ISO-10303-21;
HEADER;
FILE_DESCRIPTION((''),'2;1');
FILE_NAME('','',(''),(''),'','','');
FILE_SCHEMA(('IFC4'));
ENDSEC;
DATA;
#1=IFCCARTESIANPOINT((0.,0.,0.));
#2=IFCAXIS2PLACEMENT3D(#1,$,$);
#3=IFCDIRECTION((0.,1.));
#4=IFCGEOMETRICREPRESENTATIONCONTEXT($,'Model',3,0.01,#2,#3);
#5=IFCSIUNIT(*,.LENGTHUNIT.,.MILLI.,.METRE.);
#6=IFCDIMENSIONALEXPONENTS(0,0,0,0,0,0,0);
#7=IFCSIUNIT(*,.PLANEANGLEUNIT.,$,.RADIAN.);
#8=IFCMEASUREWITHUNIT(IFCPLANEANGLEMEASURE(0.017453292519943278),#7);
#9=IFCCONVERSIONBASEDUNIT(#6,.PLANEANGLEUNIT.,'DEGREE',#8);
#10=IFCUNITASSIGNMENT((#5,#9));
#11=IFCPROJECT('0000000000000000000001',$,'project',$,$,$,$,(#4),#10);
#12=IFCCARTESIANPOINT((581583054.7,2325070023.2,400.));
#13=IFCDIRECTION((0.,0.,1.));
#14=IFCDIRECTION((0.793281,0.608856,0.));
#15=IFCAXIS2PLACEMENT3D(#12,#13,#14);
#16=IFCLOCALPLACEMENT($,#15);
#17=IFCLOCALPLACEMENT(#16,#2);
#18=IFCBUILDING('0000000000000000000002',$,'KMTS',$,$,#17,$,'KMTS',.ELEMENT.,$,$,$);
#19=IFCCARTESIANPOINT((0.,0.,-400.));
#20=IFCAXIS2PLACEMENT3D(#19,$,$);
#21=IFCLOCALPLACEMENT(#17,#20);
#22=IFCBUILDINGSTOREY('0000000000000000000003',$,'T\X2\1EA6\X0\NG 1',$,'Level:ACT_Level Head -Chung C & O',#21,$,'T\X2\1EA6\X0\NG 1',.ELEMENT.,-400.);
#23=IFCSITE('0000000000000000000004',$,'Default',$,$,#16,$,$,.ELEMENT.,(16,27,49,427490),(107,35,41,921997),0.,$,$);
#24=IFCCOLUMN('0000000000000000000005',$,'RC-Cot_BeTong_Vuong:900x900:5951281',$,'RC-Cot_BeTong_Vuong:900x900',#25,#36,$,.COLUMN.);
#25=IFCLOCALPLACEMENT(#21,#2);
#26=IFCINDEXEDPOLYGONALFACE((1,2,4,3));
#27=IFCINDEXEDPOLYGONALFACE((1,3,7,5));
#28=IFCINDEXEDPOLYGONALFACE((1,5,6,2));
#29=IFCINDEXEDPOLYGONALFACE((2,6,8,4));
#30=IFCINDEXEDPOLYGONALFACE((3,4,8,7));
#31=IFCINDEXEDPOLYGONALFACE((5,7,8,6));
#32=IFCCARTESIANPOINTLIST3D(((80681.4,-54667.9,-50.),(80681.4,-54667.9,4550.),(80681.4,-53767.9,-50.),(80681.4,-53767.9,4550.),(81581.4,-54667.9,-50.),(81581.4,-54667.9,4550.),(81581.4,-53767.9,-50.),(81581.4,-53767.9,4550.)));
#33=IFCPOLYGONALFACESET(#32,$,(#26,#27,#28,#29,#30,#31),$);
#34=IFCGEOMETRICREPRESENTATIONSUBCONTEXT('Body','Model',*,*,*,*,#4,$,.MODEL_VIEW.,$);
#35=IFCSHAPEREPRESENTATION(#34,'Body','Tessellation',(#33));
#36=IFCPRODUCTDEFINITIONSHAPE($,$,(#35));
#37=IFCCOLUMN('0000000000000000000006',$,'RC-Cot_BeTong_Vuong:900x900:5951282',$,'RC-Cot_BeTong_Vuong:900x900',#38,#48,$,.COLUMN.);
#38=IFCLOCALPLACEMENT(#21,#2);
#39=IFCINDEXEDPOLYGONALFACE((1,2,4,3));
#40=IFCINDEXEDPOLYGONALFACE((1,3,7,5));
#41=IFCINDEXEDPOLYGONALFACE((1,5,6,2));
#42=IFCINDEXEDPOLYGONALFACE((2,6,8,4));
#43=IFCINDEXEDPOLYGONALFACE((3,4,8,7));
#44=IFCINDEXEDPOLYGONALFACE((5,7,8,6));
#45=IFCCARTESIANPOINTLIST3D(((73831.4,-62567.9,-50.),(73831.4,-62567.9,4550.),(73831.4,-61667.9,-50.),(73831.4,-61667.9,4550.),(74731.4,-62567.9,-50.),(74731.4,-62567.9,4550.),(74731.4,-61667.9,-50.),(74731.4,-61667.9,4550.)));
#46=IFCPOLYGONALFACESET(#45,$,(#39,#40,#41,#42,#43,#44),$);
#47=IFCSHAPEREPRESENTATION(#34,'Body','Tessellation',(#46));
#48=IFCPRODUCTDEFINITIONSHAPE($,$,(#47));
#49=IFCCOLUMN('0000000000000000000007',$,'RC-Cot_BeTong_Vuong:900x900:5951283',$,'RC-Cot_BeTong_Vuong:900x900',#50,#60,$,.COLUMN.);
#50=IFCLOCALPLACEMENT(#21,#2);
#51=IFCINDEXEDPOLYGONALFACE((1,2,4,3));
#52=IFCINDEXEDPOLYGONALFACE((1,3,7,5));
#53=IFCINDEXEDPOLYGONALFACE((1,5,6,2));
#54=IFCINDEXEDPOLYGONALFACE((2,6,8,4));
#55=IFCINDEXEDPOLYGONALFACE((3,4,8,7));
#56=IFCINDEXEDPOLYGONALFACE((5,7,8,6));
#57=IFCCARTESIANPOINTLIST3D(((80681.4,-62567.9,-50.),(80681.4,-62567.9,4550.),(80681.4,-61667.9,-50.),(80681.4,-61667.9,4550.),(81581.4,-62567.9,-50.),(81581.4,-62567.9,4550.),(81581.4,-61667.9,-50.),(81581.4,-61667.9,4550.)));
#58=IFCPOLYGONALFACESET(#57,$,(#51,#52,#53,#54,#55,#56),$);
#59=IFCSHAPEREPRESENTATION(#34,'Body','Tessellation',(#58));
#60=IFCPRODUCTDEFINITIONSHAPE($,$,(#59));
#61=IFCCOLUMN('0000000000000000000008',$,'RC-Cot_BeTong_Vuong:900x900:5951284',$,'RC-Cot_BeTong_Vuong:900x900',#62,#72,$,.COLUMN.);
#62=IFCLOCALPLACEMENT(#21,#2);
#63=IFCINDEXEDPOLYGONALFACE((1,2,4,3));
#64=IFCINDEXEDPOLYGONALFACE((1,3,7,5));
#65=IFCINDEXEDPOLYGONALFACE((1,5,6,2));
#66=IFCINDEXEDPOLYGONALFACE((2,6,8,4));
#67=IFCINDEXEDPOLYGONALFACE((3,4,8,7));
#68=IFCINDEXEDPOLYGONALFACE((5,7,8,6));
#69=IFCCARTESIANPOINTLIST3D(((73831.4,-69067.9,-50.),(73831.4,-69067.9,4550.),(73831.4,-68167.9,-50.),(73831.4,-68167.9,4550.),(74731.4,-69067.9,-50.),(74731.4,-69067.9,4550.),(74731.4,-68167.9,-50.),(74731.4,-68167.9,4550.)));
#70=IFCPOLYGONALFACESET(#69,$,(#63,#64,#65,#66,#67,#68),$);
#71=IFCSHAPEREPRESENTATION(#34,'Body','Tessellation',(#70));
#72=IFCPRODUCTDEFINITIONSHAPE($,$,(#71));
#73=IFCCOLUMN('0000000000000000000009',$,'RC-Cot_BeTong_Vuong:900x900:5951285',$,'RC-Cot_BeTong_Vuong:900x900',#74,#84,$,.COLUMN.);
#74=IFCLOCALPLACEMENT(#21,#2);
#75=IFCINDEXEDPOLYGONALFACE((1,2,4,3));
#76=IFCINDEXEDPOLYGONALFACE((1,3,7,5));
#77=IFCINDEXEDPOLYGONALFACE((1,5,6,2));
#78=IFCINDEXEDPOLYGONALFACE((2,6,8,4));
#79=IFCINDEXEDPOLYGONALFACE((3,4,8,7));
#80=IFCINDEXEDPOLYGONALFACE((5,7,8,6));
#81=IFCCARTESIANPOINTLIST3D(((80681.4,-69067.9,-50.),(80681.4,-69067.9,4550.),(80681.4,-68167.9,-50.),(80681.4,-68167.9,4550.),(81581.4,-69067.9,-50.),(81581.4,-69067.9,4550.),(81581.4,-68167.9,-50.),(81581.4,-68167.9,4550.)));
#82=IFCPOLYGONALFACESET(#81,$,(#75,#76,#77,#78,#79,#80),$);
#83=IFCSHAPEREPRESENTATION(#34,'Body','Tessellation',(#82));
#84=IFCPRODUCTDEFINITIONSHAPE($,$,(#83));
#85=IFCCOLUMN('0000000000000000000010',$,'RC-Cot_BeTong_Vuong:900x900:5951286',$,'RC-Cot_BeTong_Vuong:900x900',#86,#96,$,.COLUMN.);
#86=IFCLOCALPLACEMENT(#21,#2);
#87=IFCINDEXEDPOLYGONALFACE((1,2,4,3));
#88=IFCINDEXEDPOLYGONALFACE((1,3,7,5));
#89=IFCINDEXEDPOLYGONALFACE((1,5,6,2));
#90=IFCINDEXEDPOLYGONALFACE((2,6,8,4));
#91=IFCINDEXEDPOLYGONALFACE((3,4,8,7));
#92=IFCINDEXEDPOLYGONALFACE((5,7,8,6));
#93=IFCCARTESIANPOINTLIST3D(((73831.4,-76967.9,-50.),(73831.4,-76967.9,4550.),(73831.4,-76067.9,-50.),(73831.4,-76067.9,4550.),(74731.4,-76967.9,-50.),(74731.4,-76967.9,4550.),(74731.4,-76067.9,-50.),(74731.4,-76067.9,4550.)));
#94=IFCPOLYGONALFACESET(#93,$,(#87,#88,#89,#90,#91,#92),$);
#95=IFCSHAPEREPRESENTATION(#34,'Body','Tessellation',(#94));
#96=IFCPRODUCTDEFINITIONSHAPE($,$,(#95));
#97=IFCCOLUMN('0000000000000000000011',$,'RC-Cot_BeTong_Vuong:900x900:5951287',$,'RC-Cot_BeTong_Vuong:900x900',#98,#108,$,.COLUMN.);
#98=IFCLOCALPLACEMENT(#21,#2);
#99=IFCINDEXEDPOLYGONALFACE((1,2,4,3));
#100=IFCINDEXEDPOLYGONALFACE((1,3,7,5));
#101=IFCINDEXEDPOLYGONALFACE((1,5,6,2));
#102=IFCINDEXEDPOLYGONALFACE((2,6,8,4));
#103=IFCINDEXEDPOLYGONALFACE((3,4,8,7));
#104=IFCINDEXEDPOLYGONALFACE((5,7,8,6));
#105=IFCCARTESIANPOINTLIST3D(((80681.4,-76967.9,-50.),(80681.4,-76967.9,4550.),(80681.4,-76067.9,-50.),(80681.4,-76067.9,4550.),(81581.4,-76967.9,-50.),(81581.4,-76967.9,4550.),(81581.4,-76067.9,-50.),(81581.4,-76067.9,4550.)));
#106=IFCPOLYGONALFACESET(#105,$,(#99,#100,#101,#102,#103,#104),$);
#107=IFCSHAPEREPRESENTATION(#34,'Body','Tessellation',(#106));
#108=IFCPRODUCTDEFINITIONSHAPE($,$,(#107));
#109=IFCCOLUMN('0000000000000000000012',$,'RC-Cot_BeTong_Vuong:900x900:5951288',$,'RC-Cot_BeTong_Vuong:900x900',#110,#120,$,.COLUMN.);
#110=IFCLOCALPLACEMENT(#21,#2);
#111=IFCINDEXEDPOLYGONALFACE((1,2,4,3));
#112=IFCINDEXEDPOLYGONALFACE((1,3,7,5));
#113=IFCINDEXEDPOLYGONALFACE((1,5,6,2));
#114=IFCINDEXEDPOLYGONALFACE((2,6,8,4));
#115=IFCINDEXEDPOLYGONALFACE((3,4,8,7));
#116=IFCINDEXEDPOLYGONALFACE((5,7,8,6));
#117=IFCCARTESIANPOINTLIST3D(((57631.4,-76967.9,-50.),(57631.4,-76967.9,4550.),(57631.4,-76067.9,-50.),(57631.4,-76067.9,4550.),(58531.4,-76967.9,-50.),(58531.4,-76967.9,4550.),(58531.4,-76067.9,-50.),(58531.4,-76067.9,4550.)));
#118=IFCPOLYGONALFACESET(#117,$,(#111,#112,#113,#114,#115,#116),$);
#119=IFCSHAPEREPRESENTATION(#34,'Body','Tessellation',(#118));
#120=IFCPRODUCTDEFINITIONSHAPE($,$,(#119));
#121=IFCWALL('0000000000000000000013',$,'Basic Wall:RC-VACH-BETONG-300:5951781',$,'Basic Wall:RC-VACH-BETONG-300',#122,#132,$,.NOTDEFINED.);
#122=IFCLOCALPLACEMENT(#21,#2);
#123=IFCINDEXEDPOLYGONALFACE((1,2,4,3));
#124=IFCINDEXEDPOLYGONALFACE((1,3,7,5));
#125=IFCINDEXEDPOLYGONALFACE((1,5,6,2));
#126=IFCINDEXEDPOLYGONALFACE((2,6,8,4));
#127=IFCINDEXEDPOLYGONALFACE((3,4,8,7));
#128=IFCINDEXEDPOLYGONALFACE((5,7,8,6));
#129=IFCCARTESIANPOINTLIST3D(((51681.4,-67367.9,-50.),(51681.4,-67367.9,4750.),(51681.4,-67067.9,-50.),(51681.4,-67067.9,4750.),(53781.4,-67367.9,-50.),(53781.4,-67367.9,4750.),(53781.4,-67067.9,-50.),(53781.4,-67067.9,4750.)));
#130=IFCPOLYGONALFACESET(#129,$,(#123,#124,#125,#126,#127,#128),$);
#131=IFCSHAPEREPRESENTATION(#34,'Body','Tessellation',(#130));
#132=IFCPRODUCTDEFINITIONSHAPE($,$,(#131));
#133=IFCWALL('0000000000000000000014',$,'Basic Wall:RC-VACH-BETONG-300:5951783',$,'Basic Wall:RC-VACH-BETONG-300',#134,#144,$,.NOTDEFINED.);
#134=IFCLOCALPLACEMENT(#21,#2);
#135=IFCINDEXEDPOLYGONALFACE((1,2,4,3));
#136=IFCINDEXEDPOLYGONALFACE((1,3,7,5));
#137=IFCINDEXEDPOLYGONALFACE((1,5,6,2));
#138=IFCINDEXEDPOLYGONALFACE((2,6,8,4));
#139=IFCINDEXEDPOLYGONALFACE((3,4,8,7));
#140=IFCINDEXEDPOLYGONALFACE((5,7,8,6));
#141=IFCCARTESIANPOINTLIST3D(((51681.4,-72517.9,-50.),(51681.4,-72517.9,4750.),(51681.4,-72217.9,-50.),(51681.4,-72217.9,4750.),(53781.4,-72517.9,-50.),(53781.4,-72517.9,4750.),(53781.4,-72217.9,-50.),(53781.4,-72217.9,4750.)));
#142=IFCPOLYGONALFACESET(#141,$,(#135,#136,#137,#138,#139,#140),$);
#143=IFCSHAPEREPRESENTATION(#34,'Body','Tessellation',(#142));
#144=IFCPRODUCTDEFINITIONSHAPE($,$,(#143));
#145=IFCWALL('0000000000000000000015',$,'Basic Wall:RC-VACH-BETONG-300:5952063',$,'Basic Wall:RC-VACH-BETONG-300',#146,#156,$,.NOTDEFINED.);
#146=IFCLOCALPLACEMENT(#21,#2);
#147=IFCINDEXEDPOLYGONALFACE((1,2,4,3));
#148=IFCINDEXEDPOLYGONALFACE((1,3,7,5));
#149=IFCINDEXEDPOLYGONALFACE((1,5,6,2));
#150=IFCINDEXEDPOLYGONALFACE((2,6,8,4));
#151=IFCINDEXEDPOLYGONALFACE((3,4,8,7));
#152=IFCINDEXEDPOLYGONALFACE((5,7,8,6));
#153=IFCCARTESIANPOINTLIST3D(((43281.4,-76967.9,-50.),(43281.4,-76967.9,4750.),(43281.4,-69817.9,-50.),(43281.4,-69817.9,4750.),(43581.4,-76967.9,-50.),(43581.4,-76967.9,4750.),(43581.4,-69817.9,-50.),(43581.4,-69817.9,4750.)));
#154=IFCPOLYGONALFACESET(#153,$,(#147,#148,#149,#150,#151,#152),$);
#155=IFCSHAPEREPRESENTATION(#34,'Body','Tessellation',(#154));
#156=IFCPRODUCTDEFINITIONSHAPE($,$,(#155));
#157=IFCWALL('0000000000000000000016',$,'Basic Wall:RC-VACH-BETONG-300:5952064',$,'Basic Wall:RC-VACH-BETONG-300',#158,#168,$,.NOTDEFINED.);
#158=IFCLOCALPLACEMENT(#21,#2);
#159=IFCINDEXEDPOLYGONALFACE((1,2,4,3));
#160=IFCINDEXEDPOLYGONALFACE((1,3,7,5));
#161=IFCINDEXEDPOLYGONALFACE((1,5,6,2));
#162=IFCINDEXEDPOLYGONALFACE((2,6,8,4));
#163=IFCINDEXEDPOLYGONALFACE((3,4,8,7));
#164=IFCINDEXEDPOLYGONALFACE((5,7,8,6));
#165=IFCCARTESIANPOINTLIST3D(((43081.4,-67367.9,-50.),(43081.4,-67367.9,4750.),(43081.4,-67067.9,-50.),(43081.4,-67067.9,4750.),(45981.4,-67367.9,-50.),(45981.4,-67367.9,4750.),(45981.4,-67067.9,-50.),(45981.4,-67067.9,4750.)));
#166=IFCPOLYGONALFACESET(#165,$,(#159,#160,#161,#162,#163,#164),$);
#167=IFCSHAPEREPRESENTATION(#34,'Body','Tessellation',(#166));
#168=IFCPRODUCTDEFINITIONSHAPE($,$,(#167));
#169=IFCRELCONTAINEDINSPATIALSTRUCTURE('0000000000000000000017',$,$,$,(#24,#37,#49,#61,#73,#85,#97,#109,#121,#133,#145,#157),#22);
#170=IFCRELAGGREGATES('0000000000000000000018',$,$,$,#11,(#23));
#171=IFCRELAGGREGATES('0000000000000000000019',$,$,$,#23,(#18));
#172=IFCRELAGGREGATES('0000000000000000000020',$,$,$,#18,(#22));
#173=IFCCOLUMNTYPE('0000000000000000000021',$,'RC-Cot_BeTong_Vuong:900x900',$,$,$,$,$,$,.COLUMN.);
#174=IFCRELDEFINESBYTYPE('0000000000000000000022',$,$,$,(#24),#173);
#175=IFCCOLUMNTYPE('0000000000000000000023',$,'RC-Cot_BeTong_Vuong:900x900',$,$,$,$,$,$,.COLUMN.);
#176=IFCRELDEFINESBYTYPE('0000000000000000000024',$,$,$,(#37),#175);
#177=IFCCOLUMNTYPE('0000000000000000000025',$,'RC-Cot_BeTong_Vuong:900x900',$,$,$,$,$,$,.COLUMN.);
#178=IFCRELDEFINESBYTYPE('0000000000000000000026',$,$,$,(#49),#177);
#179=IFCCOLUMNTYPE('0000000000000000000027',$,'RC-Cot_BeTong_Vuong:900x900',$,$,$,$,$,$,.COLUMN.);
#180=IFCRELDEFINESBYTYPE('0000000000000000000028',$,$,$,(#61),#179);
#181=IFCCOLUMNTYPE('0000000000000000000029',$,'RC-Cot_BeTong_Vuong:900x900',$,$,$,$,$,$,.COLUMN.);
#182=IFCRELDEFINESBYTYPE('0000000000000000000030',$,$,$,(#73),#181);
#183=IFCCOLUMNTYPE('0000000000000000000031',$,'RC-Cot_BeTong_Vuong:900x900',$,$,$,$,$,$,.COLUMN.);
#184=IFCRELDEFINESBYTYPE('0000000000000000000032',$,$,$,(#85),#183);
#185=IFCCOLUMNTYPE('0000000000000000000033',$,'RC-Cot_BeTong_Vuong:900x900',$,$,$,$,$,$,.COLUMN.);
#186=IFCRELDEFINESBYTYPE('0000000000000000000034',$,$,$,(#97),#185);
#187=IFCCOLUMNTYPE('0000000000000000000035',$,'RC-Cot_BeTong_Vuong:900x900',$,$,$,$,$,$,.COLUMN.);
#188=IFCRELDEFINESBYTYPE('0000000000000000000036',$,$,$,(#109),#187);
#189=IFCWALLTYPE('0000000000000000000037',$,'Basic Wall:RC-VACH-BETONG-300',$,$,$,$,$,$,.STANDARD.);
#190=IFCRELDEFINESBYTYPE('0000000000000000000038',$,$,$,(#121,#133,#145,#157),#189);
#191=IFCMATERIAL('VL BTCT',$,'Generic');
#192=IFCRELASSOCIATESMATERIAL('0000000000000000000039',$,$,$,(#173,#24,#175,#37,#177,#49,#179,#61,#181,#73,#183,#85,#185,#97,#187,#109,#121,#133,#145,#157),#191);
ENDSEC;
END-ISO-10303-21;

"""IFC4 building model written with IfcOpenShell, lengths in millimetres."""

from ifc_helpers import new_model, entity, si_unit, converted_unit, direction, frame, origin, place, context, subcontext, project, spatial, indexed_curve, outline, extrude, source, transform, mapped, material, type_object, type_shapes, element, save


model = new_model("IFC4")

# Units and contexts
model_context = context("Model", 3, precision=0.01, world=origin(), true_north=direction((0.0, 1.0)))
body_context = subcontext(model_context, "Body", "Model", "MODEL_VIEW")
ifc_project = project(units=[si_unit("LENGTHUNIT", "METRE", prefix="MILLI"), converted_unit("PLANEANGLEUNIT", "DEGREE", entity("IfcPlaneAngleMeasure", 0.017453292519943278), si_unit("PLANEANGLEUNIT", "RADIAN"), dimensions=[0, 0, 0, 0, 0, 0, 0])], contexts=[model_context])

# Site, building, storey
site_placement = place(None, frame((581583054.7, 2325070023.2, 400.0), z_axis=(0.0, 0.0, 1.0), x_axis=(0.793281, 0.608856, 0.0)))
site = spatial("IfcSite", under=ifc_project, at=site_placement, Name="Default", CompositionType="ELEMENT", RefLatitude=(16, 27, 49, 427490), RefLongitude=(107, 35, 41, 921997), RefElevation=0.0)
building_placement = place(site_placement, origin())
building = spatial("IfcBuilding", under=site, at=building_placement, Name="KMTS", LongName="KMTS", CompositionType="ELEMENT")
storey_placement = place(building_placement, frame((0.0, 0.0, -400.0)))
storey = spatial("IfcBuildingStorey", under=building, at=storey_placement, Name="TẦNG 1", ObjectType="Level:ACT_Level Head -Chung C & O", LongName="TẦNG 1", CompositionType="ELEMENT", Elevation=-400.0)

# Columns
ifc_material = material(Name="VL BTCT", Category="Generic")
column_type_1 = type_object("IfcColumnType", Name="RC-Cot_BeTong_Vuong:900x900", PredefinedType="COLUMN", material=ifc_material)
shared_shape_1 = source(origin(), body_context, "Body", "SweptSolid", [
    extrude(outline(indexed_curve([(-450.0, -450.0), (450.0, -450.0), (450.0, 450.0), (-450.0, 450.0), (-450.0, -450.0)], self_intersect=False)), frame((81131.4, -54217.9, -450.0), z_axis=(0.0, 0.0, 1.0), x_axis=(-1.0, 0.0, 0.0)), (0.0, 0.0, 1.0), 4600.0),
])
type_shapes(column_type_1, [shared_shape_1])
column_1_placement = place(storey_placement, frame((0.0, 0.0, 400.0)))
element("IfcColumn", 1, at=column_1_placement, inside=storey, type_object=column_type_1, material=ifc_material, Name="RC-Cot_BeTong_Vuong:900x900:5951281", ObjectType="RC-Cot_BeTong_Vuong:900x900", PredefinedType="COLUMN", context=body_context, shape_type="MappedRepresentation", body=[
    mapped(shared_shape_1, transform((0.0, 0.0, 0.0), scale=1.0)),
])
column_type_2 = type_object("IfcColumnType", Name="RC-Cot_BeTong_Vuong:900x900", PredefinedType="COLUMN", material=ifc_material)
shared_shape_2 = source(origin(), body_context, "Body", "SweptSolid", [
    extrude(outline(indexed_curve([(-450.0, -450.0), (450.0, -450.0), (450.0, 450.0), (-450.0, 450.0), (-450.0, -450.0)], self_intersect=False)), frame((74281.4, -62117.9, -450.0), z_axis=(0.0, 0.0, 1.0), x_axis=(-1.0, 0.0, 0.0)), (0.0, 0.0, 1.0), 4600.0),
])
type_shapes(column_type_2, [shared_shape_2])
column_2_placement = place(storey_placement, frame((0.0, 0.0, 400.0)))
element("IfcColumn", 2, at=column_2_placement, inside=storey, type_object=column_type_2, material=ifc_material, Name="RC-Cot_BeTong_Vuong:900x900:5951282", ObjectType="RC-Cot_BeTong_Vuong:900x900", PredefinedType="COLUMN", context=body_context, shape_type="MappedRepresentation", body=[
    mapped(shared_shape_2, transform((0.0, 0.0, 0.0), scale=1.0)),
])
column_type_3 = type_object("IfcColumnType", Name="RC-Cot_BeTong_Vuong:900x900", PredefinedType="COLUMN", material=ifc_material)
shared_shape_3 = source(origin(), body_context, "Body", "SweptSolid", [
    extrude(outline(indexed_curve([(-450.0, -450.0), (450.0, -450.0), (450.0, 450.0), (-450.0, 450.0), (-450.0, -450.0)], self_intersect=False)), frame((81131.4, -62117.9, -450.0), z_axis=(0.0, 0.0, 1.0), x_axis=(-1.0, 0.0, 0.0)), (0.0, 0.0, 1.0), 4600.0),
])
type_shapes(column_type_3, [shared_shape_3])
column_3_placement = place(storey_placement, frame((0.0, 0.0, 400.0)))
element("IfcColumn", 3, at=column_3_placement, inside=storey, type_object=column_type_3, material=ifc_material, Name="RC-Cot_BeTong_Vuong:900x900:5951283", ObjectType="RC-Cot_BeTong_Vuong:900x900", PredefinedType="COLUMN", context=body_context, shape_type="MappedRepresentation", body=[
    mapped(shared_shape_3, transform((0.0, 0.0, 0.0), scale=1.0)),
])
column_type_4 = type_object("IfcColumnType", Name="RC-Cot_BeTong_Vuong:900x900", PredefinedType="COLUMN", material=ifc_material)
shared_shape_4 = source(origin(), body_context, "Body", "SweptSolid", [
    extrude(outline(indexed_curve([(-450.0, -450.0), (450.0, -450.0), (450.0, 450.0), (-450.0, 450.0), (-450.0, -450.0)], self_intersect=False)), frame((74281.4, -68617.9, -450.0), z_axis=(0.0, 0.0, 1.0), x_axis=(-1.0, 0.0, 0.0)), (0.0, 0.0, 1.0), 4600.0),
])
type_shapes(column_type_4, [shared_shape_4])
column_4_placement = place(storey_placement, frame((0.0, 0.0, 400.0)))
element("IfcColumn", 4, at=column_4_placement, inside=storey, type_object=column_type_4, material=ifc_material, Name="RC-Cot_BeTong_Vuong:900x900:5951284", ObjectType="RC-Cot_BeTong_Vuong:900x900", PredefinedType="COLUMN", context=body_context, shape_type="MappedRepresentation", body=[
    mapped(shared_shape_4, transform((0.0, 0.0, 0.0), scale=1.0)),
])
column_type_5 = type_object("IfcColumnType", Name="RC-Cot_BeTong_Vuong:900x900", PredefinedType="COLUMN", material=ifc_material)
shared_shape_5 = source(origin(), body_context, "Body", "SweptSolid", [
    extrude(outline(indexed_curve([(-450.0, -450.0), (450.0, -450.0), (450.0, 450.0), (-450.0, 450.0), (-450.0, -450.0)], self_intersect=False)), frame((81131.4, -68617.9, -450.0), z_axis=(0.0, 0.0, 1.0), x_axis=(-1.0, 0.0, 0.0)), (0.0, 0.0, 1.0), 4600.0),
])
type_shapes(column_type_5, [shared_shape_5])
column_5_placement = place(storey_placement, frame((0.0, 0.0, 400.0)))
element("IfcColumn", 5, at=column_5_placement, inside=storey, type_object=column_type_5, material=ifc_material, Name="RC-Cot_BeTong_Vuong:900x900:5951285", ObjectType="RC-Cot_BeTong_Vuong:900x900", PredefinedType="COLUMN", context=body_context, shape_type="MappedRepresentation", body=[
    mapped(shared_shape_5, transform((0.0, 0.0, 0.0), scale=1.0)),
])
column_type_6 = type_object("IfcColumnType", Name="RC-Cot_BeTong_Vuong:900x900", PredefinedType="COLUMN", material=ifc_material)
shared_shape_6 = source(origin(), body_context, "Body", "SweptSolid", [
    extrude(outline(indexed_curve([(-450.0, -450.0), (450.0, -450.0), (450.0, 450.0), (-450.0, 450.0), (-450.0, -450.0)], self_intersect=False)), frame((74281.4, -76517.9, -450.0), z_axis=(0.0, 0.0, 1.0), x_axis=(-1.0, 0.0, 0.0)), (0.0, 0.0, 1.0), 4600.0),
])
type_shapes(column_type_6, [shared_shape_6])
column_6_placement = place(storey_placement, frame((0.0, 0.0, 400.0)))
element("IfcColumn", 6, at=column_6_placement, inside=storey, type_object=column_type_6, material=ifc_material, Name="RC-Cot_BeTong_Vuong:900x900:5951286", ObjectType="RC-Cot_BeTong_Vuong:900x900", PredefinedType="COLUMN", context=body_context, shape_type="MappedRepresentation", body=[
    mapped(shared_shape_6, transform((0.0, 0.0, 0.0), scale=1.0)),
])
column_type_7 = type_object("IfcColumnType", Name="RC-Cot_BeTong_Vuong:900x900", PredefinedType="COLUMN", material=ifc_material)
shared_shape_7 = source(origin(), body_context, "Body", "SweptSolid", [
    extrude(outline(indexed_curve([(-450.0, -450.0), (450.0, -450.0), (450.0, 450.0), (-450.0, 450.0), (-450.0, -450.0)], self_intersect=False)), frame((81131.4, -76517.9, -450.0), z_axis=(0.0, 0.0, 1.0), x_axis=(-1.0, 0.0, 0.0)), (0.0, 0.0, 1.0), 4600.0),
])
type_shapes(column_type_7, [shared_shape_7])
column_7_placement = place(storey_placement, frame((0.0, 0.0, 400.0)))
element("IfcColumn", 7, at=column_7_placement, inside=storey, type_object=column_type_7, material=ifc_material, Name="RC-Cot_BeTong_Vuong:900x900:5951287", ObjectType="RC-Cot_BeTong_Vuong:900x900", PredefinedType="COLUMN", context=body_context, shape_type="MappedRepresentation", body=[
    mapped(shared_shape_7, transform((0.0, 0.0, 0.0), scale=1.0)),
])
column_type_8 = type_object("IfcColumnType", Name="RC-Cot_BeTong_Vuong:900x900", PredefinedType="COLUMN", material=ifc_material)
shared_shape_8 = source(origin(), body_context, "Body", "SweptSolid", [
    extrude(outline(indexed_curve([(-450.0, -450.0), (450.0, -450.0), (450.0, 450.0), (-450.0, 450.0), (-450.0, -450.0)], self_intersect=False)), frame((58081.4, -76517.9, -450.0), z_axis=(0.0, 0.0, 1.0), x_axis=(-1.0, 0.0, 0.0)), (0.0, 0.0, 1.0), 4600.0),
])
type_shapes(column_type_8, [shared_shape_8])
column_8_placement = place(storey_placement, frame((0.0, 0.0, 400.0)))
element("IfcColumn", 8, at=column_8_placement, inside=storey, type_object=column_type_8, material=ifc_material, Name="RC-Cot_BeTong_Vuong:900x900:5951288", ObjectType="RC-Cot_BeTong_Vuong:900x900", PredefinedType="COLUMN", context=body_context, shape_type="MappedRepresentation", body=[
    mapped(shared_shape_8, transform((0.0, 0.0, 0.0), scale=1.0)),
])

# Walls
wall_type_1 = type_object("IfcWallType", Name="Basic Wall:RC-VACH-BETONG-300", PredefinedType="STANDARD")
wall_1_placement = place(storey_placement, frame((53781.4, -67217.9, -50.0), z_axis=(0.0, 0.0, 1.0), x_axis=(-1.0, 0.0, 0.0)))
element("IfcWall", 9, at=wall_1_placement, inside=storey, type_object=wall_type_1, material=ifc_material, Name="Basic Wall:RC-VACH-BETONG-300:5951781", ObjectType="Basic Wall:RC-VACH-BETONG-300", PredefinedType="NOTDEFINED", context=body_context, shape_type="SweptSolid", body=[
    extrude(outline(indexed_curve([(2100.0, 150.0), (0.0, 150.0), (0.0, -150.0), (2100.0, -150.0), (2100.0, 150.0)], self_intersect=False)), origin(), (0.0, 0.0, 1.0), 4800.0),
])
wall_2_placement = place(storey_placement, frame((53781.4, -72367.9, -50.0), z_axis=(0.0, 0.0, 1.0), x_axis=(-1.0, 0.0, 0.0)))
element("IfcWall", 10, at=wall_2_placement, inside=storey, type_object=wall_type_1, material=ifc_material, Name="Basic Wall:RC-VACH-BETONG-300:5951783", ObjectType="Basic Wall:RC-VACH-BETONG-300", PredefinedType="NOTDEFINED", context=body_context, shape_type="SweptSolid", body=[
    extrude(outline(indexed_curve([(2100.0, 150.0), (0.0, 150.0), (0.0, -150.0), (2100.0, -150.0), (2100.0, 150.0)], self_intersect=False)), origin(), (0.0, 0.0, 1.0), 4800.0),
])
wall_3_placement = place(storey_placement, frame((43431.4, -69817.9, -50.0), z_axis=(0.0, 0.0, 1.0), x_axis=(0.0, -1.0, 0.0)))
element("IfcWall", 11, at=wall_3_placement, inside=storey, type_object=wall_type_1, material=ifc_material, Name="Basic Wall:RC-VACH-BETONG-300:5952063", ObjectType="Basic Wall:RC-VACH-BETONG-300", PredefinedType="NOTDEFINED", context=body_context, shape_type="SweptSolid", body=[
    extrude(outline(indexed_curve([(7150.0, 150.0), (0.0, 150.0), (0.0, -150.0), (7150.0, -150.0), (7150.0, 150.0)], self_intersect=False)), origin(), (0.0, 0.0, 1.0), 4800.0),
])
wall_4_placement = place(storey_placement, frame((45981.4, -67217.9, -50.0), z_axis=(0.0, 0.0, 1.0), x_axis=(-1.0, 0.0, 0.0)))
element("IfcWall", 12, at=wall_4_placement, inside=storey, type_object=wall_type_1, material=ifc_material, Name="Basic Wall:RC-VACH-BETONG-300:5952064", ObjectType="Basic Wall:RC-VACH-BETONG-300", PredefinedType="NOTDEFINED", context=body_context, shape_type="SweptSolid", body=[
    extrude(outline(indexed_curve([(2900.0, 150.0), (0.0, 150.0), (0.0, -150.0), (2900.0, -150.0), (2900.0, 150.0)], self_intersect=False)), origin(), (0.0, 0.0, 1.0), 4800.0),
])

save(model, "model.ifc")
